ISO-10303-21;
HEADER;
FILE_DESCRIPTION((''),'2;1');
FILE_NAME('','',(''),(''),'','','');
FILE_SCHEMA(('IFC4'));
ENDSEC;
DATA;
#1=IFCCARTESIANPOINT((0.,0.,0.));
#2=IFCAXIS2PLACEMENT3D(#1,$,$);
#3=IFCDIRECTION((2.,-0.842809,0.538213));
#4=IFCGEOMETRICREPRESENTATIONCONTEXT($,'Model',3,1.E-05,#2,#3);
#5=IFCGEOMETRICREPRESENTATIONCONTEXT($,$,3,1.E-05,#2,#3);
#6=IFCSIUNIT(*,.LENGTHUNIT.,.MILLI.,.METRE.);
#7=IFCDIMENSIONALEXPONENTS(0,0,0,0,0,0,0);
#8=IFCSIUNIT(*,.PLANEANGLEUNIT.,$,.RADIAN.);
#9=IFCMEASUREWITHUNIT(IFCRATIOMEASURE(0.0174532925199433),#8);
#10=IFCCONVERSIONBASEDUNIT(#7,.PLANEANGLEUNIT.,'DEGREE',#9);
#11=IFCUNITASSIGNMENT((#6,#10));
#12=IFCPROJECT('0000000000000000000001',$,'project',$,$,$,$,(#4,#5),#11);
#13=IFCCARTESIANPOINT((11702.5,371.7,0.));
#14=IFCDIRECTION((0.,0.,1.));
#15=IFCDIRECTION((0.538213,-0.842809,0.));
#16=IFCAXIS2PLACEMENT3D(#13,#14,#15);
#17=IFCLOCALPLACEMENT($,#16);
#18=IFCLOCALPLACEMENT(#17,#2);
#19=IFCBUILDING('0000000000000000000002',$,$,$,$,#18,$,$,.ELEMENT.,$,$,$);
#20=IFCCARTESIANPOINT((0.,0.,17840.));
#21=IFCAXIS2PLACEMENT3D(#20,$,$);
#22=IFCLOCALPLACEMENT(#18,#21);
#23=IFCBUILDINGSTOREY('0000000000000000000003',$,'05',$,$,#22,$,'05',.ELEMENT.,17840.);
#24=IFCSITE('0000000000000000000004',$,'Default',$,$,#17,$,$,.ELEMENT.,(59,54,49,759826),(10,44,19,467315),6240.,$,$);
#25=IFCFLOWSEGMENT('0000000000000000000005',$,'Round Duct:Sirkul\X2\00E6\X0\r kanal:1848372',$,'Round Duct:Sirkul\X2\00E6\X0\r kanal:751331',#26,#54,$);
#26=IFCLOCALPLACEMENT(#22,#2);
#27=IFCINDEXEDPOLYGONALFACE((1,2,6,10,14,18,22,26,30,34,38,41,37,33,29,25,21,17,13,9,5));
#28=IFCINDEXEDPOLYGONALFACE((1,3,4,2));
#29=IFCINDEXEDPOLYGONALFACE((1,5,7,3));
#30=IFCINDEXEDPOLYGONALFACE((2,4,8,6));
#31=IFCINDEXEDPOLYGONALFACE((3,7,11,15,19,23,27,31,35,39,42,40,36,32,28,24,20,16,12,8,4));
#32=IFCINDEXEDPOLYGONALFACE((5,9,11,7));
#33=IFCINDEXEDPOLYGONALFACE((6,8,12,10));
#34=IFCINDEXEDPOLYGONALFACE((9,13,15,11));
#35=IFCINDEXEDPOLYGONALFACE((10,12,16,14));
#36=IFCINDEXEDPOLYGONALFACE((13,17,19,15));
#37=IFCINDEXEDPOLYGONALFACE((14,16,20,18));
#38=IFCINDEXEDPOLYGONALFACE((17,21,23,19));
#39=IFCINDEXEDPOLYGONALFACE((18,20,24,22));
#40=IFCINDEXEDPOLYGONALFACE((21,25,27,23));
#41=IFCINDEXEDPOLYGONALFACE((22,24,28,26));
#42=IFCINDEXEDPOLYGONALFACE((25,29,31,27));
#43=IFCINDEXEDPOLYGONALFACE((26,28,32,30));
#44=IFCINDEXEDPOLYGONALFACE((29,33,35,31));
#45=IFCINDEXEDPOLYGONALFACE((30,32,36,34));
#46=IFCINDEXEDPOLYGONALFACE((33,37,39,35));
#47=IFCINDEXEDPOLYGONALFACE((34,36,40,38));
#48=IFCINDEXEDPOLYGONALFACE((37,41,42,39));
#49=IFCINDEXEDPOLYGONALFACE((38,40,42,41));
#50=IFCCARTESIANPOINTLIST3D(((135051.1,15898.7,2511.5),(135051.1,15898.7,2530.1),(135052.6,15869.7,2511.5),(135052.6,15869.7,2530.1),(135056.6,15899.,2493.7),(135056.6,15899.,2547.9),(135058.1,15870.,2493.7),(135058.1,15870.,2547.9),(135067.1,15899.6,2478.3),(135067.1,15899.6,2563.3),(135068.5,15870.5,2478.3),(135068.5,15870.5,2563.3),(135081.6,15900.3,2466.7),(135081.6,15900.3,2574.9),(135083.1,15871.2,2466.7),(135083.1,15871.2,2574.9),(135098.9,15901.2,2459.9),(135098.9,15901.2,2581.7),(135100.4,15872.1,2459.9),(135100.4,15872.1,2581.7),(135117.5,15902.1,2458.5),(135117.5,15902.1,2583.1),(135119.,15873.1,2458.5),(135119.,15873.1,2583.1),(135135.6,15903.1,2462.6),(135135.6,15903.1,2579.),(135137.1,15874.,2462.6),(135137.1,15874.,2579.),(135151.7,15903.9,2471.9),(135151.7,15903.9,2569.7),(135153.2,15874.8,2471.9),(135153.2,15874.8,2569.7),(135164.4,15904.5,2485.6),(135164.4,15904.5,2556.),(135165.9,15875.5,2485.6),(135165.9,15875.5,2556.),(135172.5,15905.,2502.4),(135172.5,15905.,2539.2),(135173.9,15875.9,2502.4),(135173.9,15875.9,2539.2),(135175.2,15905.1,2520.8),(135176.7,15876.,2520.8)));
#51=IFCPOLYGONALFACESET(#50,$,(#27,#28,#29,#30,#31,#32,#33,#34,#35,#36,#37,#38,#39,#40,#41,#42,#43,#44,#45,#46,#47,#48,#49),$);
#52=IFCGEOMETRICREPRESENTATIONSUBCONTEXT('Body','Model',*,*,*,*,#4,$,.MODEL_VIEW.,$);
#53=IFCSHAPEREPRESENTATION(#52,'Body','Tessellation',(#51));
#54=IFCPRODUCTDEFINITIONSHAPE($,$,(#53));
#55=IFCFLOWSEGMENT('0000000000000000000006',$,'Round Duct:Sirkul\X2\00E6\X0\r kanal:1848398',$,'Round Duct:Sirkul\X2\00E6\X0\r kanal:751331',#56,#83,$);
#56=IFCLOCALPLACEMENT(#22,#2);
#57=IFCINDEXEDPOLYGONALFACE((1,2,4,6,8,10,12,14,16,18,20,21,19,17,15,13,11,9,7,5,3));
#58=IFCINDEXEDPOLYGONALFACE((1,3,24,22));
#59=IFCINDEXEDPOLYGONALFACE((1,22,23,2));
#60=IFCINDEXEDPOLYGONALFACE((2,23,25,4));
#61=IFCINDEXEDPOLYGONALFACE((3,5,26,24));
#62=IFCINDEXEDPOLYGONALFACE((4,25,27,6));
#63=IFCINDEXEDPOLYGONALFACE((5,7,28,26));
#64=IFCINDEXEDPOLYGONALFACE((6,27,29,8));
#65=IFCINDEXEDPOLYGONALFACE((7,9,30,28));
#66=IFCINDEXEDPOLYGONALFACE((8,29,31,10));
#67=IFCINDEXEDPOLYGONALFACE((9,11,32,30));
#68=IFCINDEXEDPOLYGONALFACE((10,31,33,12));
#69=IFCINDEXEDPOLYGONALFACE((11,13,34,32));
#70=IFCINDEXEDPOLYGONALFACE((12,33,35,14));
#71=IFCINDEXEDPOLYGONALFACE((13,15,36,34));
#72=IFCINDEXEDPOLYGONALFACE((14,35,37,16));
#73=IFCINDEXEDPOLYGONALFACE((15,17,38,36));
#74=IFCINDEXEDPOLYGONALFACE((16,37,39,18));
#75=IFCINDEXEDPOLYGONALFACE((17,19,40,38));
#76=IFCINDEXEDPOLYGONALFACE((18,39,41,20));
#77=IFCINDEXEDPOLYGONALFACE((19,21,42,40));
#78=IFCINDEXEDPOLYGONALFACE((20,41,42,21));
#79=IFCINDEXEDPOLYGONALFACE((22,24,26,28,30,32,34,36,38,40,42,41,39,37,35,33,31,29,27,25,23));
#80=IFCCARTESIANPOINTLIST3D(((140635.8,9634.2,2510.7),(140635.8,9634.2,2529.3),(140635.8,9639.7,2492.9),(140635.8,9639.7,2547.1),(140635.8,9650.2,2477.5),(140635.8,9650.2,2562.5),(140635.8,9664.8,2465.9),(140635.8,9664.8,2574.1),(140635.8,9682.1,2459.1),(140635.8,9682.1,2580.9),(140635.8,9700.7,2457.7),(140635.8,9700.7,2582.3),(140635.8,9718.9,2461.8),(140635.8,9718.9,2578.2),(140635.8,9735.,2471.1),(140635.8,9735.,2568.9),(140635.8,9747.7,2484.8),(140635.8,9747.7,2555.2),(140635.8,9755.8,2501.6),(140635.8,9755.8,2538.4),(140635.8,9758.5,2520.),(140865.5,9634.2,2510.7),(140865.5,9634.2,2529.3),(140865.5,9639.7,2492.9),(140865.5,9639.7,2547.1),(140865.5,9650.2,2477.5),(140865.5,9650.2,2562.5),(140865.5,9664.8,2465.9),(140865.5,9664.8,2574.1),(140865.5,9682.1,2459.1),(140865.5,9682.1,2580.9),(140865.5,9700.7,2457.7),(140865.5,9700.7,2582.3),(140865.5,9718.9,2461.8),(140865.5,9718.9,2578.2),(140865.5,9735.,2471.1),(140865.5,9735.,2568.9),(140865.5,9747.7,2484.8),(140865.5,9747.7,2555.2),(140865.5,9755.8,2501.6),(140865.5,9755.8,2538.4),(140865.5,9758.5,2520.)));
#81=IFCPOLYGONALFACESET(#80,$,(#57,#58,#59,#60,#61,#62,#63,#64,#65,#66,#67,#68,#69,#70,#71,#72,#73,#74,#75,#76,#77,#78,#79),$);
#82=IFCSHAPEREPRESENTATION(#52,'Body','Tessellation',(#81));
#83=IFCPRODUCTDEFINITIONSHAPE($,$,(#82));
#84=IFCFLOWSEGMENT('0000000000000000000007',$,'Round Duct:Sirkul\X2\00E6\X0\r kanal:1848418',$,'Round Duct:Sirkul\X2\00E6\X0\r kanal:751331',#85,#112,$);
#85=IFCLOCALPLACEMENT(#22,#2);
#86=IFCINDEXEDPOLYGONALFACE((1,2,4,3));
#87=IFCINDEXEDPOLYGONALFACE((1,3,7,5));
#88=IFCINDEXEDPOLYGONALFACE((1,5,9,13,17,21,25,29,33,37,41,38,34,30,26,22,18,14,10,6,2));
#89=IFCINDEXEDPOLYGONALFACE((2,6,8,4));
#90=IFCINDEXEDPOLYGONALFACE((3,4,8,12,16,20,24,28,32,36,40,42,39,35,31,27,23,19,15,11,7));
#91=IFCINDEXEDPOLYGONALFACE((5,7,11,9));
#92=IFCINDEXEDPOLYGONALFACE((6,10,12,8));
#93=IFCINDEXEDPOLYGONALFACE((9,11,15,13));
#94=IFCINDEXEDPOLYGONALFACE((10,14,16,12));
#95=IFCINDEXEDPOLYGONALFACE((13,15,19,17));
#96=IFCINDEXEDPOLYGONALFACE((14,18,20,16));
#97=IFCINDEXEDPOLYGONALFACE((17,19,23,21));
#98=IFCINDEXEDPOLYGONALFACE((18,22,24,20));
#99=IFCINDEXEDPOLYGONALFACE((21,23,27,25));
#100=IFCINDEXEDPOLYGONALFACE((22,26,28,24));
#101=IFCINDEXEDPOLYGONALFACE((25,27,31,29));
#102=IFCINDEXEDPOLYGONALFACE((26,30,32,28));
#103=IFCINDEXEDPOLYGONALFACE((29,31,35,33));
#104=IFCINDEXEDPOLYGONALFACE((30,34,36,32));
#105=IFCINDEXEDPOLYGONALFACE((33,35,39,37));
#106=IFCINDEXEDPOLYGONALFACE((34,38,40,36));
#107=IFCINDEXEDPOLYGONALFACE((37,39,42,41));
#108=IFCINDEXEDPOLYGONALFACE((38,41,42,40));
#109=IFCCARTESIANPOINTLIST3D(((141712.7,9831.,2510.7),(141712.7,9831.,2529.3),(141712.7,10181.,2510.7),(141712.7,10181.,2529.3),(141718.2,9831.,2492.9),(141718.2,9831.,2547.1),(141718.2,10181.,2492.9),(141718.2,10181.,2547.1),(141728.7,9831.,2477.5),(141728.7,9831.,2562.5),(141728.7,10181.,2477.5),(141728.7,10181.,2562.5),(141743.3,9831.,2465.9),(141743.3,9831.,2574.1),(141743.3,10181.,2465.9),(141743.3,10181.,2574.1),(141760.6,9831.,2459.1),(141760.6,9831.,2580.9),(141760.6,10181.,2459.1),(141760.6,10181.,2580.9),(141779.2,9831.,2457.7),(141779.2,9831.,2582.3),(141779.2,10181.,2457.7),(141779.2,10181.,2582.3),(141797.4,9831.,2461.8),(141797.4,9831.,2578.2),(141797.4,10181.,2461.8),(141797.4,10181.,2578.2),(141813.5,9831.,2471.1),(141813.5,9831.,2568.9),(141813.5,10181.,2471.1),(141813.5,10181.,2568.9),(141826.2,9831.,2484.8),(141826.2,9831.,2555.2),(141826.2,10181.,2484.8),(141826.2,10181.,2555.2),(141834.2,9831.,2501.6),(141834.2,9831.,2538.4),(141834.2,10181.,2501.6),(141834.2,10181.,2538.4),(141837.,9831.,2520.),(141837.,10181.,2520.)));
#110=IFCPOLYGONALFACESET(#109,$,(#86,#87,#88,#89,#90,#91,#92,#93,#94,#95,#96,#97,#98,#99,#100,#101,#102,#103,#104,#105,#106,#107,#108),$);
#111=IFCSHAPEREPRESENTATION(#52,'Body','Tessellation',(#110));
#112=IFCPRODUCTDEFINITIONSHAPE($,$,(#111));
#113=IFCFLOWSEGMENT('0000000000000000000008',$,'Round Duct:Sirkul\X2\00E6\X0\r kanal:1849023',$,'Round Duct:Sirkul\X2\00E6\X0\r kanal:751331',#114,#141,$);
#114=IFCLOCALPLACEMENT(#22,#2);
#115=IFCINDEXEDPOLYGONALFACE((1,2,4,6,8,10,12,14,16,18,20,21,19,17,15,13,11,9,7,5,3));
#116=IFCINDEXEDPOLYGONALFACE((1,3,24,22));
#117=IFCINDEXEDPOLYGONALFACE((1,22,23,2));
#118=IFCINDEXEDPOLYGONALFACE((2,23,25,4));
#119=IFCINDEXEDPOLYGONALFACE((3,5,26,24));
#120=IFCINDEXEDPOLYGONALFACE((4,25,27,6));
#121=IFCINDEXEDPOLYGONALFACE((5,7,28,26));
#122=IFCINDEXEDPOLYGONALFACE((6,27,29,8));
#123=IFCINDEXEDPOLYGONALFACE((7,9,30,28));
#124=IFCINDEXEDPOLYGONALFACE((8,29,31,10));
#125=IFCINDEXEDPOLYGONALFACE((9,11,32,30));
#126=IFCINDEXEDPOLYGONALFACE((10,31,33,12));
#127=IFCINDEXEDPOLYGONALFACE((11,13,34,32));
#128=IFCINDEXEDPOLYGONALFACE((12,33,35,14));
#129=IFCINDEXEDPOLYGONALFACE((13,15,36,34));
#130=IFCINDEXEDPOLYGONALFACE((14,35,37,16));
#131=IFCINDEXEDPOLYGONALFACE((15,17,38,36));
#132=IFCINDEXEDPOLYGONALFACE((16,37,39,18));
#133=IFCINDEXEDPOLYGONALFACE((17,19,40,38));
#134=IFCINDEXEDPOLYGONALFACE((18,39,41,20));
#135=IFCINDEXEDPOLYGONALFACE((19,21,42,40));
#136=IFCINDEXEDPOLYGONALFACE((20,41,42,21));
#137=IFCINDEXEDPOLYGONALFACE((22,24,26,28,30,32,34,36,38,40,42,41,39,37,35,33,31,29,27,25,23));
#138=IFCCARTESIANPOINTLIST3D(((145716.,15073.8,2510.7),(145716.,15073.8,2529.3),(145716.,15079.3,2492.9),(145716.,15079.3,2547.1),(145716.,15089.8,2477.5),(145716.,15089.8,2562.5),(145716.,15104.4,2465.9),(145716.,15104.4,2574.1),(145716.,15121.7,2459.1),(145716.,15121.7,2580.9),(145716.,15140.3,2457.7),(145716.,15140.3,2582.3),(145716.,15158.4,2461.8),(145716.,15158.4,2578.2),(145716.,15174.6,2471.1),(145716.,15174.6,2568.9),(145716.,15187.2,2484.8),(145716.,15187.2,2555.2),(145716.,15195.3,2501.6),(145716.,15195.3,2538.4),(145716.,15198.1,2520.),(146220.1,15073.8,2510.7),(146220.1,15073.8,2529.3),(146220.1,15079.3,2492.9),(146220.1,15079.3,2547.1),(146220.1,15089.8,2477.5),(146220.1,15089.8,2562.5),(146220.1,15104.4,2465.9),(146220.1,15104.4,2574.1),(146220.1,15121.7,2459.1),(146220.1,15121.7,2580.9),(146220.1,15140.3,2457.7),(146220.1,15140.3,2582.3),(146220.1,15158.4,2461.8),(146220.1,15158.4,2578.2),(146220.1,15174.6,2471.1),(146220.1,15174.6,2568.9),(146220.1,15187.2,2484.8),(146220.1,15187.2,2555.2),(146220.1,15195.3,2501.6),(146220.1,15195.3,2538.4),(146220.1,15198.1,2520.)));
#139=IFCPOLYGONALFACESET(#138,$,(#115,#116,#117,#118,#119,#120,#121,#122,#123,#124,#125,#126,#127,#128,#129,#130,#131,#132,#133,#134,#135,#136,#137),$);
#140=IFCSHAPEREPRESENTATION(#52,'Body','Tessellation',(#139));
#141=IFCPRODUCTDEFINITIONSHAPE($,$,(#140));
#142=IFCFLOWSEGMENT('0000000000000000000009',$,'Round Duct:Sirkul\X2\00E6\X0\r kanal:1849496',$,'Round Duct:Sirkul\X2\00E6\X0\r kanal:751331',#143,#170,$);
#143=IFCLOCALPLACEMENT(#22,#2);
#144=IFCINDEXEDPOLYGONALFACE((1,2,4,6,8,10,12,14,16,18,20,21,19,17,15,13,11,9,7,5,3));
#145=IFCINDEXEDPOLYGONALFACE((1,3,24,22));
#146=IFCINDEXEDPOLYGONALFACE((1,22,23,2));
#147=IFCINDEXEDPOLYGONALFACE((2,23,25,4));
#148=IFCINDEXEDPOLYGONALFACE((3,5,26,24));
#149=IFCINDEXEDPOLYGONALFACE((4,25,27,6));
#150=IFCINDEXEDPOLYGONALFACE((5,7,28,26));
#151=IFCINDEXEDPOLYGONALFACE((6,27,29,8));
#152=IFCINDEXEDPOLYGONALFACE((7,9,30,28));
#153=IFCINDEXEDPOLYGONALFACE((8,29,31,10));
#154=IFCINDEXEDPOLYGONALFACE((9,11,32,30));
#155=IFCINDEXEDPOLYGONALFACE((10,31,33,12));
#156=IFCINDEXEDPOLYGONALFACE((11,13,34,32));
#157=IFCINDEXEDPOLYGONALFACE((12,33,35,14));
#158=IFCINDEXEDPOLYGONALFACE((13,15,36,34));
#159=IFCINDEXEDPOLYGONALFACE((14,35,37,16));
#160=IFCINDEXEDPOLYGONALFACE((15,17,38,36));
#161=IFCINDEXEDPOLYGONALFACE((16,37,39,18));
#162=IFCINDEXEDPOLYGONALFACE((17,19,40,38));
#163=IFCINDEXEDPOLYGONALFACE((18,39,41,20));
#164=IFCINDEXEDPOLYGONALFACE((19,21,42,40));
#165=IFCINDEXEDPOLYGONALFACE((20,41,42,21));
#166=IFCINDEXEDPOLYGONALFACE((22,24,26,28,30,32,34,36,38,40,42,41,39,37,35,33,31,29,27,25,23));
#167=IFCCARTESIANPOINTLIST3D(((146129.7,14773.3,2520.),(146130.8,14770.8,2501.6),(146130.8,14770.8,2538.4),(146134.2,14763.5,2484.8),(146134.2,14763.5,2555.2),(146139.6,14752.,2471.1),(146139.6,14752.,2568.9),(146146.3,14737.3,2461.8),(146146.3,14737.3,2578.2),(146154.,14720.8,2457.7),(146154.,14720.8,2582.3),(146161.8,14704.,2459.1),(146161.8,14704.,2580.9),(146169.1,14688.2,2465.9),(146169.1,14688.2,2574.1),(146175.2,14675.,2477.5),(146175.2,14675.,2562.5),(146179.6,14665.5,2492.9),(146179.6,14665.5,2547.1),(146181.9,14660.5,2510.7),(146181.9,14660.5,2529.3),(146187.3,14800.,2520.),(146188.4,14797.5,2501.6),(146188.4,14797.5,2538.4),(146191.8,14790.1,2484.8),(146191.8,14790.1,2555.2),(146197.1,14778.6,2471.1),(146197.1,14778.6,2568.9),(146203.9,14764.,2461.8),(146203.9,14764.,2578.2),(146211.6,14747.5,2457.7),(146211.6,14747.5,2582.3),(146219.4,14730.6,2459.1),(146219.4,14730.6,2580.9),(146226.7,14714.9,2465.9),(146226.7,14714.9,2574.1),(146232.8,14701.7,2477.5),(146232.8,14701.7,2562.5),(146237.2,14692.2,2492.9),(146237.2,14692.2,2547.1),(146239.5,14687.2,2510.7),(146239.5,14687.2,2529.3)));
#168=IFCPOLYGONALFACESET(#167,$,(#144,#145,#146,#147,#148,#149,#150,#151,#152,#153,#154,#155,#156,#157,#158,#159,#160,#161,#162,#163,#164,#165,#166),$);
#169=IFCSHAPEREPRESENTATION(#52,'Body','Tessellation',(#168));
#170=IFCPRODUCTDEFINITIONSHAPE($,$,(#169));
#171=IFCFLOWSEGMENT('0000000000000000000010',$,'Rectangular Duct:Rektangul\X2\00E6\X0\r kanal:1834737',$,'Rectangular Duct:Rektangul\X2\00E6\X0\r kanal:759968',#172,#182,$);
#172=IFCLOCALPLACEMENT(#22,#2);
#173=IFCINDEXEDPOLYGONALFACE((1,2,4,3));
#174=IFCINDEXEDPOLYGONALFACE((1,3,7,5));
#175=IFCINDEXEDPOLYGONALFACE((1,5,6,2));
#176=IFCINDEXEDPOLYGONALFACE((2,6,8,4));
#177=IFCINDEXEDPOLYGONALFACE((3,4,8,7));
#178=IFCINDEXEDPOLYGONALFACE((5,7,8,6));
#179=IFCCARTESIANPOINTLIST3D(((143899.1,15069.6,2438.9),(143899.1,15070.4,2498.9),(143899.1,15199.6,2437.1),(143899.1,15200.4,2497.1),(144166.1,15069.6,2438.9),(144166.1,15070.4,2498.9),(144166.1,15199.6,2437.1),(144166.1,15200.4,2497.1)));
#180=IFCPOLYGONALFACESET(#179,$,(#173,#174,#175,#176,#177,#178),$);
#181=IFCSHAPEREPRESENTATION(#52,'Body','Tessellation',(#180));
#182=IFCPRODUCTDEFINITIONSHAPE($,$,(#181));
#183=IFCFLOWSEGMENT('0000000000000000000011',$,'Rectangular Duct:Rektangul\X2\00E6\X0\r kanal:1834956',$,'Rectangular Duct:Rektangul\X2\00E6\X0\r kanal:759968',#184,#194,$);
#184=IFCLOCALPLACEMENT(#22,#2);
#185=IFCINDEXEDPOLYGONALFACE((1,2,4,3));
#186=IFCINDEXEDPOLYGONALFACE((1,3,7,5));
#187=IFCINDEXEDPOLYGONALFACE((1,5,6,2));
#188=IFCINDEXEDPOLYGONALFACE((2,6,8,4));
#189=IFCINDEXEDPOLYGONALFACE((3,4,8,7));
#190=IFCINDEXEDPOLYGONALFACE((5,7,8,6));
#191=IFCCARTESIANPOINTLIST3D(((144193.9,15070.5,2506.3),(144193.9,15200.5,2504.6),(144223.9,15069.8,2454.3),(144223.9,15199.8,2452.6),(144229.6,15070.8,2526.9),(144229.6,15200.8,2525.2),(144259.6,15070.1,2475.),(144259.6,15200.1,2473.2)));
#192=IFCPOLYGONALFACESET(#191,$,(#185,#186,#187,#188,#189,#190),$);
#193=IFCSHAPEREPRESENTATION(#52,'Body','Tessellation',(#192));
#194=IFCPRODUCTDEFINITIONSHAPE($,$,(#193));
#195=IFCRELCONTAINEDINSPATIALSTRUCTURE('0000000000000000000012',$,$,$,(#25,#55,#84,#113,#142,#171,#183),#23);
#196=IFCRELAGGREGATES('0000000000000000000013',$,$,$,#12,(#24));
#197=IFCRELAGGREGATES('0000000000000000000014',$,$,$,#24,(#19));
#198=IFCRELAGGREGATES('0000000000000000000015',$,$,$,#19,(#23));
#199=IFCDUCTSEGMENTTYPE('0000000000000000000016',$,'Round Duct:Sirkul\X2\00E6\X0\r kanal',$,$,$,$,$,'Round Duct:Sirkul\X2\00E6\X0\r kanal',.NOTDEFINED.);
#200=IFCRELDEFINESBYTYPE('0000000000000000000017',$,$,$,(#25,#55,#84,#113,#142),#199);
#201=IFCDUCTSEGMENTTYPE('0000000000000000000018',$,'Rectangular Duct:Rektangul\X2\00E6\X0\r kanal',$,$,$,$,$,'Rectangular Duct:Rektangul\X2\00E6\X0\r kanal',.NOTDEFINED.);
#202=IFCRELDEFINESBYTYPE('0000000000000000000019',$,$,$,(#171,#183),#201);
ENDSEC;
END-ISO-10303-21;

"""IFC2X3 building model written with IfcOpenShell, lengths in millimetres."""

from ifc_helpers import new_model, entity, si_unit, converted_unit, direction, frame, frame_2d, origin, origin_2d_with_axis, place, context, subcontext, project, spatial, rectangle, circle, extrude, type_object, element, save


model = new_model("IFC2X3")

# Units and contexts
model_context = context("Model", 3, precision=1e-05, world=origin(), true_north=direction((2.0, -0.842809, 0.538213)))
context_of_model = context(None, 3, precision=1e-05, world=origin(), true_north=direction((2.0, -0.842809, 0.538213)))
body_context = subcontext(model_context, "Body", "Model", "MODEL_VIEW")
ifc_project = project(units=[si_unit("LENGTHUNIT", "METRE", prefix="MILLI"), converted_unit("PLANEANGLEUNIT", "DEGREE", entity("IfcRatioMeasure", 0.0174532925199433), si_unit("PLANEANGLEUNIT", "RADIAN"), dimensions=[0, 0, 0, 0, 0, 0, 0])], contexts=[model_context, context_of_model])

# Site, building, storey
site_placement = place(None, frame((11702.5, 371.7, 0.0), z_axis=(0.0, 0.0, 1.0), x_axis=(0.538213, -0.842809, 0.0)))
site = spatial("IfcSite", under=ifc_project, at=site_placement, Name="Default", CompositionType="ELEMENT", RefLatitude=(59, 54, 49, 759826), RefLongitude=(10, 44, 19, 467315), RefElevation=6240.0)
building_placement = place(site_placement, origin())
building = spatial("IfcBuilding", under=site, at=building_placement, CompositionType="ELEMENT")
storey_placement = place(building_placement, frame((0.0, 0.0, 17840.0)))
storey = spatial("IfcBuildingStorey", under=building, at=storey_placement, Name="05", LongName="05", CompositionType="ELEMENT", Elevation=17840.0)

# Flow segments
duct_segment_type_1 = type_object("IfcDuctSegmentType", Name="Round Duct:Sirkulær kanal", ElementType="Round Duct:Sirkulær kanal", PredefinedType="NOTDEFINED")
flow_segment_1_placement = place(storey_placement, origin())
element("IfcFlowSegment", 1, at=flow_segment_1_placement, inside=storey, type_object=duct_segment_type_1, Name="Round Duct:Sirkulær kanal:1848372", ObjectType="Round Duct:Sirkulær kanal:751331", context=body_context, shape_type="SweptSolid", body=[
    extrude(circle(Radius=62.5, at=frame_2d((0.0, 0.0), x_axis=(1.0, 0.0))), frame((135112.8, 15901.9, 2520.8), z_axis=(0.051227, -0.998687, 0.0), x_axis=(0.998687, 0.051227, 0.0)), (0.0, 0.0, 1.0), 29.1),
])
flow_segment_2_placement = place(storey_placement, origin())
element("IfcFlowSegment", 2, at=flow_segment_2_placement, inside=storey, type_object=duct_segment_type_1, Name="Round Duct:Sirkulær kanal:1848398", ObjectType="Round Duct:Sirkulær kanal:751331", context=body_context, shape_type="SweptSolid", body=[
    extrude(circle(Radius=62.5, at=frame_2d((0.0, 0.0), x_axis=(1.0, 0.0))), frame((140635.8, 9696.0, 2520.0), z_axis=(1.0, 0.0, 0.0), x_axis=(0.0, 1.0, 0.0)), (0.0, 0.0, 1.0), 229.7),
])
flow_segment_3_placement = place(storey_placement, origin())
element("IfcFlowSegment", 3, at=flow_segment_3_placement, inside=storey, type_object=duct_segment_type_1, Name="Round Duct:Sirkulær kanal:1848418", ObjectType="Round Duct:Sirkulær kanal:751331", context=body_context, shape_type="SweptSolid", body=[
    extrude(circle(Radius=62.5, at=frame_2d((0.0, 0.0), x_axis=(1.0, 0.0))), frame((141774.5, 9831.0, 2520.0), z_axis=(0.0, 1.0, 0.0), x_axis=(1.0, 0.0, 0.0)), (0.0, 0.0, 1.0), 350.0),
])
flow_segment_4_placement = place(storey_placement, origin())
element("IfcFlowSegment", 4, at=flow_segment_4_placement, inside=storey, type_object=duct_segment_type_1, Name="Round Duct:Sirkulær kanal:1849023", ObjectType="Round Duct:Sirkulær kanal:751331", context=body_context, shape_type="SweptSolid", body=[
    extrude(circle(Radius=62.5, at=origin_2d_with_axis()), frame((145716.0, 15135.6, 2520.0), z_axis=(1.0, 0.0, 0.0), x_axis=(0.0, 1.0, 0.0)), (0.0, 0.0, 1.0), 504.2),
])
flow_segment_5_placement = place(storey_placement, origin())
element("IfcFlowSegment", 5, at=flow_segment_5_placement, inside=storey, type_object=duct_segment_type_1, Name="Round Duct:Sirkulær kanal:1849496", ObjectType="Round Duct:Sirkulær kanal:751331", context=body_context, shape_type="SweptSolid", body=[
    extrude(circle(Radius=62.5, at=origin_2d_with_axis()), frame((146155.9, 14716.6, 2520.0), z_axis=(0.907459, 0.420141, 0.0), x_axis=(-0.420141, 0.907459, 0.0)), (0.0, 0.0, 1.0), 63.5),
])
duct_segment_type_2 = type_object("IfcDuctSegmentType", Name="Rectangular Duct:Rektangulær kanal", ElementType="Rectangular Duct:Rektangulær kanal", PredefinedType="NOTDEFINED")
flow_segment_6_placement = place(storey_placement, origin())
element("IfcFlowSegment", 6, at=flow_segment_6_placement, inside=storey, type_object=duct_segment_type_2, Name="Rectangular Duct:Rektangulær kanal:1834737", ObjectType="Rectangular Duct:Rektangulær kanal:759968", context=body_context, shape_type="SweptSolid", body=[
    extrude(rectangle(XDim=60.0, YDim=130.0, at=frame_2d((0.0, 0.0), x_axis=(1.0, 0.0))), frame((143899.1, 15135.0, 2468.0), z_axis=(1.0, 0.0, 0.0), x_axis=(0.0, -0.013237, -0.999912)), (0.0, 0.0, 1.0), 267.1),
])
flow_segment_7_placement = place(storey_placement, origin())
element("IfcFlowSegment", 7, at=flow_segment_7_placement, inside=storey, type_object=duct_segment_type_2, Name="Rectangular Duct:Rektangulær kanal:1834956", ObjectType="Rectangular Duct:Rektangulær kanal:759968", context=body_context, shape_type="SweptSolid", body=[
    extrude(rectangle(XDim=60.0, YDim=41.2, at=frame_2d((0.0, 0.0), x_axis=(0.0, 1.0))), frame((144226.8, 15070.3, 2490.6), z_axis=(0.0, 0.999912, -0.013237), x_axis=(0.866, 0.006619, 0.5)), (0.0, 0.0, 1.0), 130.0),
])

save(model, "model.ifc")
